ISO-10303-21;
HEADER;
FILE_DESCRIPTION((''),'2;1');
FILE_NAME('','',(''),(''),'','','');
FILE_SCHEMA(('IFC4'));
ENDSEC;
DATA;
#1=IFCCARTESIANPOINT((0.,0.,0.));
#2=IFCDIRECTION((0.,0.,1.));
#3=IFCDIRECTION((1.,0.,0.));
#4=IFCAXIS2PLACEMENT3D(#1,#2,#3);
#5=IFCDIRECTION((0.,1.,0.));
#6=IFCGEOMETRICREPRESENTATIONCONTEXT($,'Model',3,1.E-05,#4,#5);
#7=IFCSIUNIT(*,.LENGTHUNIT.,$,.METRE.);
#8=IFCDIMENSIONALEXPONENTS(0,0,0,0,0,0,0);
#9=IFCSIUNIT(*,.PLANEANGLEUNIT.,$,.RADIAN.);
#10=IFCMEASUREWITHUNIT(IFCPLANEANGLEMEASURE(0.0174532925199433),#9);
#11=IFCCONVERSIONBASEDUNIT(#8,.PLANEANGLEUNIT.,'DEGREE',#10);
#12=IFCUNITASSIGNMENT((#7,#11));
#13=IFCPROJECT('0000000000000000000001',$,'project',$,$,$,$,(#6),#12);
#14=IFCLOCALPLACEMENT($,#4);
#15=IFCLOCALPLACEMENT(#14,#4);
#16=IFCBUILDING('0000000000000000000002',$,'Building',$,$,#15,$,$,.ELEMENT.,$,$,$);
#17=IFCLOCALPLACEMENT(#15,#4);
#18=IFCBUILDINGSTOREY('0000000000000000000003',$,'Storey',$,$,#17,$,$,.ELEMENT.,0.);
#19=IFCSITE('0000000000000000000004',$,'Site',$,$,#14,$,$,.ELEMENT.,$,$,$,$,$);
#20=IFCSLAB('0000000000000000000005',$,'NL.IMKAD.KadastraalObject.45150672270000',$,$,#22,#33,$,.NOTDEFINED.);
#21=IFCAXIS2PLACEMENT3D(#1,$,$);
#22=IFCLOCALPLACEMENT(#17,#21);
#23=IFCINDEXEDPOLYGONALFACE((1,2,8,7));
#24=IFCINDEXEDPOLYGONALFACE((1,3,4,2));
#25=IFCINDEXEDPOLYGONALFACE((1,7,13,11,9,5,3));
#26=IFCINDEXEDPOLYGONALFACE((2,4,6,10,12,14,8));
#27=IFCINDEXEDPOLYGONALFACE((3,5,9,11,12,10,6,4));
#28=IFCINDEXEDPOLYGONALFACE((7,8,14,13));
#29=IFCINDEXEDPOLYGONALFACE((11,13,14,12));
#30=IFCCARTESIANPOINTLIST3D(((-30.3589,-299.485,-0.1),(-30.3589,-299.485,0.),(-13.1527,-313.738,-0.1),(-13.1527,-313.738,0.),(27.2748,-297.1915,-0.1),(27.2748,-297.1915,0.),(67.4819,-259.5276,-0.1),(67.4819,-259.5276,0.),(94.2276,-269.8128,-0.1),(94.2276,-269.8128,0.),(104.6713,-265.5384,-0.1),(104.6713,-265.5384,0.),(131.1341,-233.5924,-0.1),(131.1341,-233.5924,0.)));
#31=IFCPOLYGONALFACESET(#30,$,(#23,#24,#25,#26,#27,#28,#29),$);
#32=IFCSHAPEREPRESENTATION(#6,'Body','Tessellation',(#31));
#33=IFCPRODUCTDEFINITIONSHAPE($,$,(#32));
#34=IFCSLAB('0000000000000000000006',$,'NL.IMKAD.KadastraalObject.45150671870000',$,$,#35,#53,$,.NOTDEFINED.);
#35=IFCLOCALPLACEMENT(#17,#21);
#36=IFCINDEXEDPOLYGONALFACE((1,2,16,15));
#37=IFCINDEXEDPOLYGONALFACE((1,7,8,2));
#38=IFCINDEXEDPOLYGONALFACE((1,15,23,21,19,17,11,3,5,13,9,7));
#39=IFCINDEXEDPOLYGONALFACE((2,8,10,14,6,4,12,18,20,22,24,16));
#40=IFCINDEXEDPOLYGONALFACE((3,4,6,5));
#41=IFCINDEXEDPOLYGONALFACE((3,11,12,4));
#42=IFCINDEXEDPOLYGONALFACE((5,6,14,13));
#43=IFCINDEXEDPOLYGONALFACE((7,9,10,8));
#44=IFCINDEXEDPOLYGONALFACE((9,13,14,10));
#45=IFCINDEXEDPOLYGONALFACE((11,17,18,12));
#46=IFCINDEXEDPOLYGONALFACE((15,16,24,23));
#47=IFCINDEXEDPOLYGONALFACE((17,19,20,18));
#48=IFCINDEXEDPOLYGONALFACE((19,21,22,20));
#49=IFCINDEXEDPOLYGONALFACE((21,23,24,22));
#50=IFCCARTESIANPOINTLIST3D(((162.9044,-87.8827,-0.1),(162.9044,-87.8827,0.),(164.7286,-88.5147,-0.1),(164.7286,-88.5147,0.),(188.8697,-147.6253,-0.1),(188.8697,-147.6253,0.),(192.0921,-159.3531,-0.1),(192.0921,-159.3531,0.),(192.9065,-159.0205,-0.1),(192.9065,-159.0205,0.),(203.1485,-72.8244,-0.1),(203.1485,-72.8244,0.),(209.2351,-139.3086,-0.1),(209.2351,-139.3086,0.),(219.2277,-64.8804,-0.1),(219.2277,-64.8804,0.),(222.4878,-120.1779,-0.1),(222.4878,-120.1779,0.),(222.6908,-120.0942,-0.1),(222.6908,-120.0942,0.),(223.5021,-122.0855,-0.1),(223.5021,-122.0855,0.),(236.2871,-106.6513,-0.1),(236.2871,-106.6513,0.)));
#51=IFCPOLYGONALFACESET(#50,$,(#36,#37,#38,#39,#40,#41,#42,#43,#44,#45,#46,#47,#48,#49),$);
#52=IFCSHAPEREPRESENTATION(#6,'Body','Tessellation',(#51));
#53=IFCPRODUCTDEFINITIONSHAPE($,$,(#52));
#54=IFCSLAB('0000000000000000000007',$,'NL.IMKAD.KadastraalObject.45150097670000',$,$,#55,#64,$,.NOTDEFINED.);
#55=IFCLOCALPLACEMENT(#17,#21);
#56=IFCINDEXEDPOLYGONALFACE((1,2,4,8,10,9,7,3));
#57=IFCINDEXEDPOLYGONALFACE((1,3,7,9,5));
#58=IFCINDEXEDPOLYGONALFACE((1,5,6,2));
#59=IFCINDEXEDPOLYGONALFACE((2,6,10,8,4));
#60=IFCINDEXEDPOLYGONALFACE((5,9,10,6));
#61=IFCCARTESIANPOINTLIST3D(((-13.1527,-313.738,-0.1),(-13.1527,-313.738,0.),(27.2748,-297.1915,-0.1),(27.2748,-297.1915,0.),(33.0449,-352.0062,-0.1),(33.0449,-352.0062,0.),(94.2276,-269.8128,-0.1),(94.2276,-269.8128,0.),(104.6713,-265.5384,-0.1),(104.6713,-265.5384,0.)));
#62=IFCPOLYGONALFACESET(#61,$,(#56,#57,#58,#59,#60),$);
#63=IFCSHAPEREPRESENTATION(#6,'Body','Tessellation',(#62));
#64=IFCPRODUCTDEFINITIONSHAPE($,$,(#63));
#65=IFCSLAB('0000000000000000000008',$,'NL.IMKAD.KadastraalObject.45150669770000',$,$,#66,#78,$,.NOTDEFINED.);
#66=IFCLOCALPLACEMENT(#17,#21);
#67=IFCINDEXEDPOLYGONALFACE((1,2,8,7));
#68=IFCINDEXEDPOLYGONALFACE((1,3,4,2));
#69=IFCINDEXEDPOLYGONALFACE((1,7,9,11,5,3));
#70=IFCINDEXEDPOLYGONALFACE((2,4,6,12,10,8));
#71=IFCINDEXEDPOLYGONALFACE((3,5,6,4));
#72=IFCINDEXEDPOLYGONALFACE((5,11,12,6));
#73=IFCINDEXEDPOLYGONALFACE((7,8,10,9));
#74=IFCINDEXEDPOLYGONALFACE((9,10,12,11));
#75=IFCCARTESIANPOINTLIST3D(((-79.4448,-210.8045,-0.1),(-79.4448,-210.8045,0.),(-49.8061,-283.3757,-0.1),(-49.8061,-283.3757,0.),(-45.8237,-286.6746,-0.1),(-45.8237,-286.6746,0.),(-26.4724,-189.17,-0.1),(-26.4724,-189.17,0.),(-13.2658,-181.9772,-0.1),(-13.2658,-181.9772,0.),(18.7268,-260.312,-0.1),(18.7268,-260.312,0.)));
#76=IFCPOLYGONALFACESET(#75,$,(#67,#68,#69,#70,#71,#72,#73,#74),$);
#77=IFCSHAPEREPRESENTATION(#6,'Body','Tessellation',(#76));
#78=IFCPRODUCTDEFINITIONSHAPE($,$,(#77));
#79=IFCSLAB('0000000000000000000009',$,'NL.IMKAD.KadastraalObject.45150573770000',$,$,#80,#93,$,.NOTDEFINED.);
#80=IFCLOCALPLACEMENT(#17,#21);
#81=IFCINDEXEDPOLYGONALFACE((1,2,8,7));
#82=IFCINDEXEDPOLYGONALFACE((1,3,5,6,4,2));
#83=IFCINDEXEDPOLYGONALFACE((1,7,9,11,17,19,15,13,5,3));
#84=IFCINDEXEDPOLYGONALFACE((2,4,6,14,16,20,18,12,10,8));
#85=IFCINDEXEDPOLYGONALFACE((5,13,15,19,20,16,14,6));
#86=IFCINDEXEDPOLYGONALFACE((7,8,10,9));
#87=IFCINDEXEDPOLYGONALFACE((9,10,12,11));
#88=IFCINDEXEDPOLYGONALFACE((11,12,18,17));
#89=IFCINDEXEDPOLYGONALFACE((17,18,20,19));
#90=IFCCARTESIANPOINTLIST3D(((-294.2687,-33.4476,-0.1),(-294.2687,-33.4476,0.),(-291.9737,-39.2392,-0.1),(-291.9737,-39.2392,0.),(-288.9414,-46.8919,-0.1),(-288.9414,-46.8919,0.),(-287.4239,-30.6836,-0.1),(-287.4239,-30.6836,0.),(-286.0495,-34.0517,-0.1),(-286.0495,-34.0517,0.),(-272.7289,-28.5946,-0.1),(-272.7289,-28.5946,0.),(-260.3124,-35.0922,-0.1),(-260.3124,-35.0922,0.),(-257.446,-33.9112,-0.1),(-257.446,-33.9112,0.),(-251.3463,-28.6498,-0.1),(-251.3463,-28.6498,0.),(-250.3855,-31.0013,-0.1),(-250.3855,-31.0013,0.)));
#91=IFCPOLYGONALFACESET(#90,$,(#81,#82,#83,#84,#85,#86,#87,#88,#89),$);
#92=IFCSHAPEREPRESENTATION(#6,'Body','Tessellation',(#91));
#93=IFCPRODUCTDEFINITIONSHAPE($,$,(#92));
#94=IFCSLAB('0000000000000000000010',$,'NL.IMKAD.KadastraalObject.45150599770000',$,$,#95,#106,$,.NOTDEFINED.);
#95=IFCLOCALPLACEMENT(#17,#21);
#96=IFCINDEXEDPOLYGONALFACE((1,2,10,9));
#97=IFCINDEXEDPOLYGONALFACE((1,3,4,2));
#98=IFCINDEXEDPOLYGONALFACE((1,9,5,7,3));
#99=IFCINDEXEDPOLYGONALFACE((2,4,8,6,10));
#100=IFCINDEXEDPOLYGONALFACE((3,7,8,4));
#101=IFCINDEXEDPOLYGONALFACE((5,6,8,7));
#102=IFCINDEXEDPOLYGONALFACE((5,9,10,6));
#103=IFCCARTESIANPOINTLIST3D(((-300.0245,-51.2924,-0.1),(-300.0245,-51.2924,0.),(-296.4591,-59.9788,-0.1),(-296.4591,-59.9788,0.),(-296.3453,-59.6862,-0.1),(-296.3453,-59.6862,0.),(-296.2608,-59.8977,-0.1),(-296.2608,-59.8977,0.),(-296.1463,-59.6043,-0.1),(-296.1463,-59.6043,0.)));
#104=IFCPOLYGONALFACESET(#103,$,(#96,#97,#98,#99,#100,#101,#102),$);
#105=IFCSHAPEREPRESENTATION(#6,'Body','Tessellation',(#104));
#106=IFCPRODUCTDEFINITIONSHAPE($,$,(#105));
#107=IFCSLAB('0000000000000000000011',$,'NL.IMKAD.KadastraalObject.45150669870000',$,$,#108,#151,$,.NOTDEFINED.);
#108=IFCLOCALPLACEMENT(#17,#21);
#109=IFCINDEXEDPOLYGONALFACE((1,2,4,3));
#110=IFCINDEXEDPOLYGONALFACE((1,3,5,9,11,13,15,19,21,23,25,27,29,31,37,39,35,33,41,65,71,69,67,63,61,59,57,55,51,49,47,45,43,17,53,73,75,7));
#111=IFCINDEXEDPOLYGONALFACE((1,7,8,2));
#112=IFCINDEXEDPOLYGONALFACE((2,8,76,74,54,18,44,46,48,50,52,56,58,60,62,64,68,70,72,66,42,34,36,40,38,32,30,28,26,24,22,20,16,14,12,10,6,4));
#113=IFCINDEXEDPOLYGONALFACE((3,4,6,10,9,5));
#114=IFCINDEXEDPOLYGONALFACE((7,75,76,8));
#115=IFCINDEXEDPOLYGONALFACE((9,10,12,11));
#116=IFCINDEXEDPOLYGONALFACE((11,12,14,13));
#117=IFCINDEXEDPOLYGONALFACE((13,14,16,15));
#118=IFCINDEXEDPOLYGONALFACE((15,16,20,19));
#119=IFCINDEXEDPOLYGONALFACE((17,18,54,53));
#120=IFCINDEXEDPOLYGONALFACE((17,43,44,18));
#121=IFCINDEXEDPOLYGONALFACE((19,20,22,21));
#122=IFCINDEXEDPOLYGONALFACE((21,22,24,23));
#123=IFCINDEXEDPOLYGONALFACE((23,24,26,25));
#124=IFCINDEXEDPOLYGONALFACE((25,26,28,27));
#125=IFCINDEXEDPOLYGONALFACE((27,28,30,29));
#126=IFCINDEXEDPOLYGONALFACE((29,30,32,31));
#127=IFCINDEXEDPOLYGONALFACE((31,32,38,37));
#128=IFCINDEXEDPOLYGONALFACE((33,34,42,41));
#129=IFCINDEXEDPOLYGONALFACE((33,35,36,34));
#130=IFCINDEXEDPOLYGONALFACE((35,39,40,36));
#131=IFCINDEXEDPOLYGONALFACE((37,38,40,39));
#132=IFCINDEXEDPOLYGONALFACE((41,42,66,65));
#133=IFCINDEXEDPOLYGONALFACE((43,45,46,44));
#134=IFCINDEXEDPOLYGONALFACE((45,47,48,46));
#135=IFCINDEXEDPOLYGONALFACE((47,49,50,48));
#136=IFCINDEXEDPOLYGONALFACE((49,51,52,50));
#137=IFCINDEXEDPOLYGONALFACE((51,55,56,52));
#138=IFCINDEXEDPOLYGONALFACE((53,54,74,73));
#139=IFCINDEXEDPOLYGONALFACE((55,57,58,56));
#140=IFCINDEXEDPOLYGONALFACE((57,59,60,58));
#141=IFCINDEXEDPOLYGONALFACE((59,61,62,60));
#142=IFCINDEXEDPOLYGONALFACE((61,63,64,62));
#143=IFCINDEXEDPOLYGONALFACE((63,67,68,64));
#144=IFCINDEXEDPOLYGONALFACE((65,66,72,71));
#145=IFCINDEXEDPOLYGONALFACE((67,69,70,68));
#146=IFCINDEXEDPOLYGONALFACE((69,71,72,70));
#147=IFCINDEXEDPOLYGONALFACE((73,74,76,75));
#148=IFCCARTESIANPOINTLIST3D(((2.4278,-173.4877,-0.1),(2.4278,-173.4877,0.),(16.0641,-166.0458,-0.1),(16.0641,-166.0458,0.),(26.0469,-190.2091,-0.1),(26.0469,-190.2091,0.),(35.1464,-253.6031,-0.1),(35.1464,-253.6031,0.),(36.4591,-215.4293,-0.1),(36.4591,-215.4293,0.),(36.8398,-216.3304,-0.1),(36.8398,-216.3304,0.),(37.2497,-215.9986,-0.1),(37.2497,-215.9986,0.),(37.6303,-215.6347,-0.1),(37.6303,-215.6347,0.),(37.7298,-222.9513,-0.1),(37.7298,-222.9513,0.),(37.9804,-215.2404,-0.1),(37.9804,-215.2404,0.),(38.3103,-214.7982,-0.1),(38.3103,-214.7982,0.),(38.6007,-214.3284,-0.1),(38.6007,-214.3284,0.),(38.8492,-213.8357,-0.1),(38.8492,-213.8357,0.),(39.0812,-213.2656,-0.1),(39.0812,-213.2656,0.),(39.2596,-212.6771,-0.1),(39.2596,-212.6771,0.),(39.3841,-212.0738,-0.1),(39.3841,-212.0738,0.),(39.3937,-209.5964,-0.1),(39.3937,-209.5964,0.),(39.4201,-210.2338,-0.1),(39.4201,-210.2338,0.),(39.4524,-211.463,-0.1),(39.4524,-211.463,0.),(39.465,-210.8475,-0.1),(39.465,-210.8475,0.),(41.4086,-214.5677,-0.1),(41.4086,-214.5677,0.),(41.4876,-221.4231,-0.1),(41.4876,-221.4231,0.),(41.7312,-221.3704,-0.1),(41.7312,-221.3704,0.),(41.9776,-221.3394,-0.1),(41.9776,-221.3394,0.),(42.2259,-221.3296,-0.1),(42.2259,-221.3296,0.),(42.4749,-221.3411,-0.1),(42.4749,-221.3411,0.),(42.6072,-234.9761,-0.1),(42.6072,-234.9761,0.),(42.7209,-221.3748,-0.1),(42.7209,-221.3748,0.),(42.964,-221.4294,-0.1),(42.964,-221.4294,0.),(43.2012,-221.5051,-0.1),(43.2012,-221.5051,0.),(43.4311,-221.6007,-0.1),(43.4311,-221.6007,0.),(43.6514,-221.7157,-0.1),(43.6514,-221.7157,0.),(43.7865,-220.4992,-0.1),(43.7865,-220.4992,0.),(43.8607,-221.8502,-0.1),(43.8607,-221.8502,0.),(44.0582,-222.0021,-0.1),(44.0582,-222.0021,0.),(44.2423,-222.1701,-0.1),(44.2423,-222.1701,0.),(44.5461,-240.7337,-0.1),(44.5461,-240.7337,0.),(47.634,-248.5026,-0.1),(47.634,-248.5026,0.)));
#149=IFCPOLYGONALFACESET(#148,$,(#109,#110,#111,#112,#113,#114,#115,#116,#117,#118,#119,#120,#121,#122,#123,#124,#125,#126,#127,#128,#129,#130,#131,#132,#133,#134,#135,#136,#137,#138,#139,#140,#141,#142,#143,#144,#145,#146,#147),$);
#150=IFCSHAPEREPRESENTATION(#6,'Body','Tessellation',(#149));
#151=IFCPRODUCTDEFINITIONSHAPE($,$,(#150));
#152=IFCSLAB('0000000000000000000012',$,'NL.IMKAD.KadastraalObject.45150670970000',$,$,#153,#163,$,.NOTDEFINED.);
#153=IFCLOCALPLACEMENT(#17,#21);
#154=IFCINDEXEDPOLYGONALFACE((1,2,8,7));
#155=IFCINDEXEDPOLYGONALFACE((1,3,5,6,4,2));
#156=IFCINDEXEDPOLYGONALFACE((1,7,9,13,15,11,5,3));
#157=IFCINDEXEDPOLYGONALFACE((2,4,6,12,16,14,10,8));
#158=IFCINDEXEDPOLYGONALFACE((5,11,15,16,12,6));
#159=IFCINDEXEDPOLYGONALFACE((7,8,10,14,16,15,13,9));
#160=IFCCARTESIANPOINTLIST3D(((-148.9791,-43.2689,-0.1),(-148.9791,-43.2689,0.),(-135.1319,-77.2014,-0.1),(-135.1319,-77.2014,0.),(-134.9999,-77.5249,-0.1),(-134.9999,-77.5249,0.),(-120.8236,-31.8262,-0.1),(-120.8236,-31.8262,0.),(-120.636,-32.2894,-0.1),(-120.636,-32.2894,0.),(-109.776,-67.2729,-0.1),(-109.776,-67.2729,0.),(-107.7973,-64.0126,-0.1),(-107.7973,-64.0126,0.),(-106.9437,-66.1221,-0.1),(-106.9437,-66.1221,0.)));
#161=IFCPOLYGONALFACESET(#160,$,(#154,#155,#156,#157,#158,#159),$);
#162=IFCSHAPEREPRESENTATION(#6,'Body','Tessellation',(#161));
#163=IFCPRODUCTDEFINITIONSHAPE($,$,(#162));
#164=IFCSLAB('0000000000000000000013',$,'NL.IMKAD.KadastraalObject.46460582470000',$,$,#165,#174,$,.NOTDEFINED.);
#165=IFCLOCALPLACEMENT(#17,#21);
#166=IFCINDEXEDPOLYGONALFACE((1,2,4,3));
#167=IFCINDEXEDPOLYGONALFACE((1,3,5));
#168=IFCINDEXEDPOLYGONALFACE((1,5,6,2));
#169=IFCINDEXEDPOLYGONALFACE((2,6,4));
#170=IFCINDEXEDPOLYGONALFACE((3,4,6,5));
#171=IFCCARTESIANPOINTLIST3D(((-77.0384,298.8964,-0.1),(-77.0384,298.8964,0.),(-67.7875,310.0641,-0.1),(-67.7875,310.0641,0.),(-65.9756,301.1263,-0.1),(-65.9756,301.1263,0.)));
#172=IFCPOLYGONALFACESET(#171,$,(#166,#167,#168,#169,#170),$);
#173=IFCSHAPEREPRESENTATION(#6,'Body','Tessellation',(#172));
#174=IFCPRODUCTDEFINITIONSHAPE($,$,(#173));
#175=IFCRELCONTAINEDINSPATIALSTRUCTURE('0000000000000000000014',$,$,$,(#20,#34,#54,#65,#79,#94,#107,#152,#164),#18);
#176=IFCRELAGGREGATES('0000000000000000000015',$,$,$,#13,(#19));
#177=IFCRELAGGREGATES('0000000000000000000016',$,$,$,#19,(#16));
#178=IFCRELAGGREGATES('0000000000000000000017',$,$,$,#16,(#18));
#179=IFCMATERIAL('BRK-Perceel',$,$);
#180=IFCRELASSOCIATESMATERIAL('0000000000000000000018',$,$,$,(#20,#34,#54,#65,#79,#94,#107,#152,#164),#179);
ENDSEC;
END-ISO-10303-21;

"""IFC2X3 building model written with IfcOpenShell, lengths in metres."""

from ifc_helpers import new_model, entity, si_unit, converted_unit, direction, frame, origin_with_axes, place, context, project, spatial, polyline, outline, extrude, material, element, save


model = new_model("IFC2X3")

# Units and contexts
model_context = context("Model", 3, precision=1e-05, world=origin_with_axes(), true_north=direction((0.0, 1.0, 0.0)))
ifc_project = project(units=[si_unit("LENGTHUNIT", "METRE"), converted_unit("PLANEANGLEUNIT", "DEGREE", entity("IfcPlaneAngleMeasure", 0.0174532925199433), si_unit("PLANEANGLEUNIT", "RADIAN"), dimensions=[0, 0, 0, 0, 0, 0, 0])], contexts=[model_context])

# Site, building, storey
site_placement = place(None, origin_with_axes())
site = spatial("IfcSite", under=ifc_project, at=site_placement, Name="Site", CompositionType="ELEMENT")
building_placement = place(site_placement, origin_with_axes())
building = spatial("IfcBuilding", under=site, at=building_placement, Name="Building", CompositionType="ELEMENT")
storey_placement = place(building_placement, origin_with_axes())
storey = spatial("IfcBuildingStorey", under=building, at=storey_placement, Name="Storey", CompositionType="ELEMENT", Elevation=0.0)

# Slabs
ifc_material = material(Name="BRK-Perceel")
slab_1_placement = place(storey_placement, frame((0.0, 0.0, -0.1), z_axis=(0.0, 0.0, 1.0), x_axis=(1.0, 0.0, 0.0)))
element("IfcSlab", 1, at=slab_1_placement, inside=storey, material=ifc_material, Name="NL.IMKAD.KadastraalObject.45150672270000", PredefinedType="NOTDEFINED", context=model_context, shape_type="SweptSolid", body=[
    extrude(outline(polyline([(67.4819, -259.5276), (131.1341, -233.5924), (104.6713, -265.5384), (94.2276, -269.8128), (27.2748, -297.1915), (-13.1527, -313.738), (-30.3589, -299.485), (67.4819, -259.5276)])), origin_with_axes(), (0.0, 0.0, 1.0), 0.1),
])
slab_2_placement = place(storey_placement, frame((0.0, 0.0, -0.1), z_axis=(0.0, 0.0, 1.0), x_axis=(1.0, 0.0, 0.0)))
element("IfcSlab", 2, at=slab_2_placement, inside=storey, material=ifc_material, Name="NL.IMKAD.KadastraalObject.45150671870000", PredefinedType="NOTDEFINED", context=model_context, shape_type="SweptSolid", body=[
    extrude(outline(polyline([(192.0921, -159.3531), (162.9044, -87.8827), (219.2277, -64.8804), (236.2871, -106.6513), (223.5021, -122.0855), (222.6908, -120.0942), (222.4878, -120.1779), (203.1485, -72.8244), (164.7286, -88.5147), (188.8697, -147.6253), (209.2351, -139.3086), (192.9065, -159.0205), (192.0921, -159.3531)])), origin_with_axes(), (0.0, 0.0, 1.0), 0.1),
])
slab_3_placement = place(storey_placement, frame((0.0, 0.0, -0.1), z_axis=(0.0, 0.0, 1.0), x_axis=(1.0, 0.0, 0.0)))
element("IfcSlab", 3, at=slab_3_placement, inside=storey, material=ifc_material, Name="NL.IMKAD.KadastraalObject.45150097670000", PredefinedType="NOTDEFINED", context=model_context, shape_type="SweptSolid", body=[
    extrude(outline(polyline([(27.2748, -297.1915), (94.2276, -269.8128), (104.6713, -265.5384), (33.0449, -352.0062), (-13.1527, -313.738), (27.2748, -297.1915)])), origin_with_axes(), (0.0, 0.0, 1.0), 0.1),
])
slab_4_placement = place(storey_placement, frame((0.0, 0.0, -0.1), z_axis=(0.0, 0.0, 1.0), x_axis=(1.0, 0.0, 0.0)))
element("IfcSlab", 4, at=slab_4_placement, inside=storey, material=ifc_material, Name="NL.IMKAD.KadastraalObject.45150669770000", PredefinedType="NOTDEFINED", context=model_context, shape_type="SweptSolid", body=[
    extrude(outline(polyline([(-79.4448, -210.8045), (-26.4724, -189.17), (-13.2658, -181.9772), (18.7268, -260.312), (-45.8237, -286.6746), (-49.8061, -283.3757), (-79.4448, -210.8045)])), origin_with_axes(), (0.0, 0.0, 1.0), 0.1),
])
slab_5_placement = place(storey_placement, frame((0.0, 0.0, -0.1), z_axis=(0.0, 0.0, 1.0), x_axis=(1.0, 0.0, 0.0)))
element("IfcSlab", 5, at=slab_5_placement, inside=storey, material=ifc_material, Name="NL.IMKAD.KadastraalObject.45150573770000", PredefinedType="NOTDEFINED", context=model_context, shape_type="SweptSolid", body=[
    extrude(outline(polyline([(-294.2687, -33.4476), (-287.4239, -30.6836), (-286.0495, -34.0517), (-272.7289, -28.5946), (-251.3463, -28.6498), (-250.3855, -31.0013), (-257.446, -33.9112), (-260.3124, -35.0922), (-288.9414, -46.8919), (-291.9737, -39.2392), (-294.2687, -33.4476)])), origin_with_axes(), (0.0, 0.0, 1.0), 0.1),
])
slab_6_placement = place(storey_placement, frame((0.0, 0.0, -0.1), z_axis=(0.0, 0.0, 1.0), x_axis=(1.0, 0.0, 0.0)))
element("IfcSlab", 6, at=slab_6_placement, inside=storey, material=ifc_material, Name="NL.IMKAD.KadastraalObject.45150599770000", PredefinedType="NOTDEFINED", context=model_context, shape_type="SweptSolid", body=[
    extrude(outline(polyline([(-300.0245, -51.2924), (-296.1463, -59.6043), (-296.3453, -59.6862), (-296.2608, -59.8977), (-296.4591, -59.9788), (-300.0245, -51.2924)])), origin_with_axes(), (0.0, 0.0, 1.0), 0.1),
])
slab_7_placement = place(storey_placement, frame((0.0, 0.0, -0.1), z_axis=(0.0, 0.0, 1.0), x_axis=(1.0, 0.0, 0.0)))
element("IfcSlab", 7, at=slab_7_placement, inside=storey, material=ifc_material, Name="NL.IMKAD.KadastraalObject.45150669870000", PredefinedType="NOTDEFINED", context=model_context, shape_type="SweptSolid", body=[
    extrude(outline(polyline([(35.1464, -253.6031), (2.4278, -173.4877), (16.0641, -166.0458), (26.0469, -190.2091), (36.4591, -215.4293), (36.8398, -216.3304), (37.2497, -215.9986), (37.6303, -215.6347), (37.9804, -215.2404), (38.3103, -214.7982), (38.6007, -214.3284), (38.8492, -213.8357), (39.0812, -213.2656), (39.2596, -212.6771), (39.3841, -212.0738), (39.4524, -211.463), (39.465, -210.8475), (39.4201, -210.2338), (39.3937, -209.5964), (41.4086, -214.5677), (43.7865, -220.4992), (44.2423, -222.1701), (44.0582, -222.0021), (43.8607, -221.8502), (43.6514, -221.7157), (43.4311, -221.6007), (43.2012, -221.5051), (42.964, -221.4294), (42.7209, -221.3748), (42.4749, -221.3411), (42.2259, -221.3296), (41.9776, -221.3394), (41.7312, -221.3704), (41.4876, -221.4231), (37.7298, -222.9513), (42.6072, -234.9761), (44.5461, -240.7337), (47.634, -248.5026), (35.1464, -253.6031)])), origin_with_axes(), (0.0, 0.0, 1.0), 0.1),
])
slab_8_placement = place(storey_placement, frame((0.0, 0.0, -0.1), z_axis=(0.0, 0.0, 1.0), x_axis=(1.0, 0.0, 0.0)))
element("IfcSlab", 8, at=slab_8_placement, inside=storey, material=ifc_material, Name="NL.IMKAD.KadastraalObject.45150670970000", PredefinedType="NOTDEFINED", context=model_context, shape_type="SweptSolid", body=[
    extrude(outline(polyline([(-109.776, -67.2729), (-134.9999, -77.5249), (-135.1319, -77.2014), (-148.9791, -43.2689), (-120.8236, -31.8262), (-120.636, -32.2894), (-107.7973, -64.0126), (-106.9437, -66.1221), (-109.776, -67.2729)])), origin_with_axes(), (0.0, 0.0, 1.0), 0.1),
])
slab_9_placement = place(storey_placement, frame((0.0, 0.0, -0.1), z_axis=(0.0, 0.0, 1.0), x_axis=(1.0, 0.0, 0.0)))
element("IfcSlab", 9, at=slab_9_placement, inside=storey, material=ifc_material, Name="NL.IMKAD.KadastraalObject.46460582470000", PredefinedType="NOTDEFINED", context=model_context, shape_type="SweptSolid", body=[
    extrude(outline(polyline([(-65.9756, 301.1263), (-77.0384, 298.8964), (-67.7875, 310.0641), (-65.9756, 301.1263)])), origin_with_axes(), (0.0, 0.0, 1.0), 0.1),
])

save(model, "model.ifc")
